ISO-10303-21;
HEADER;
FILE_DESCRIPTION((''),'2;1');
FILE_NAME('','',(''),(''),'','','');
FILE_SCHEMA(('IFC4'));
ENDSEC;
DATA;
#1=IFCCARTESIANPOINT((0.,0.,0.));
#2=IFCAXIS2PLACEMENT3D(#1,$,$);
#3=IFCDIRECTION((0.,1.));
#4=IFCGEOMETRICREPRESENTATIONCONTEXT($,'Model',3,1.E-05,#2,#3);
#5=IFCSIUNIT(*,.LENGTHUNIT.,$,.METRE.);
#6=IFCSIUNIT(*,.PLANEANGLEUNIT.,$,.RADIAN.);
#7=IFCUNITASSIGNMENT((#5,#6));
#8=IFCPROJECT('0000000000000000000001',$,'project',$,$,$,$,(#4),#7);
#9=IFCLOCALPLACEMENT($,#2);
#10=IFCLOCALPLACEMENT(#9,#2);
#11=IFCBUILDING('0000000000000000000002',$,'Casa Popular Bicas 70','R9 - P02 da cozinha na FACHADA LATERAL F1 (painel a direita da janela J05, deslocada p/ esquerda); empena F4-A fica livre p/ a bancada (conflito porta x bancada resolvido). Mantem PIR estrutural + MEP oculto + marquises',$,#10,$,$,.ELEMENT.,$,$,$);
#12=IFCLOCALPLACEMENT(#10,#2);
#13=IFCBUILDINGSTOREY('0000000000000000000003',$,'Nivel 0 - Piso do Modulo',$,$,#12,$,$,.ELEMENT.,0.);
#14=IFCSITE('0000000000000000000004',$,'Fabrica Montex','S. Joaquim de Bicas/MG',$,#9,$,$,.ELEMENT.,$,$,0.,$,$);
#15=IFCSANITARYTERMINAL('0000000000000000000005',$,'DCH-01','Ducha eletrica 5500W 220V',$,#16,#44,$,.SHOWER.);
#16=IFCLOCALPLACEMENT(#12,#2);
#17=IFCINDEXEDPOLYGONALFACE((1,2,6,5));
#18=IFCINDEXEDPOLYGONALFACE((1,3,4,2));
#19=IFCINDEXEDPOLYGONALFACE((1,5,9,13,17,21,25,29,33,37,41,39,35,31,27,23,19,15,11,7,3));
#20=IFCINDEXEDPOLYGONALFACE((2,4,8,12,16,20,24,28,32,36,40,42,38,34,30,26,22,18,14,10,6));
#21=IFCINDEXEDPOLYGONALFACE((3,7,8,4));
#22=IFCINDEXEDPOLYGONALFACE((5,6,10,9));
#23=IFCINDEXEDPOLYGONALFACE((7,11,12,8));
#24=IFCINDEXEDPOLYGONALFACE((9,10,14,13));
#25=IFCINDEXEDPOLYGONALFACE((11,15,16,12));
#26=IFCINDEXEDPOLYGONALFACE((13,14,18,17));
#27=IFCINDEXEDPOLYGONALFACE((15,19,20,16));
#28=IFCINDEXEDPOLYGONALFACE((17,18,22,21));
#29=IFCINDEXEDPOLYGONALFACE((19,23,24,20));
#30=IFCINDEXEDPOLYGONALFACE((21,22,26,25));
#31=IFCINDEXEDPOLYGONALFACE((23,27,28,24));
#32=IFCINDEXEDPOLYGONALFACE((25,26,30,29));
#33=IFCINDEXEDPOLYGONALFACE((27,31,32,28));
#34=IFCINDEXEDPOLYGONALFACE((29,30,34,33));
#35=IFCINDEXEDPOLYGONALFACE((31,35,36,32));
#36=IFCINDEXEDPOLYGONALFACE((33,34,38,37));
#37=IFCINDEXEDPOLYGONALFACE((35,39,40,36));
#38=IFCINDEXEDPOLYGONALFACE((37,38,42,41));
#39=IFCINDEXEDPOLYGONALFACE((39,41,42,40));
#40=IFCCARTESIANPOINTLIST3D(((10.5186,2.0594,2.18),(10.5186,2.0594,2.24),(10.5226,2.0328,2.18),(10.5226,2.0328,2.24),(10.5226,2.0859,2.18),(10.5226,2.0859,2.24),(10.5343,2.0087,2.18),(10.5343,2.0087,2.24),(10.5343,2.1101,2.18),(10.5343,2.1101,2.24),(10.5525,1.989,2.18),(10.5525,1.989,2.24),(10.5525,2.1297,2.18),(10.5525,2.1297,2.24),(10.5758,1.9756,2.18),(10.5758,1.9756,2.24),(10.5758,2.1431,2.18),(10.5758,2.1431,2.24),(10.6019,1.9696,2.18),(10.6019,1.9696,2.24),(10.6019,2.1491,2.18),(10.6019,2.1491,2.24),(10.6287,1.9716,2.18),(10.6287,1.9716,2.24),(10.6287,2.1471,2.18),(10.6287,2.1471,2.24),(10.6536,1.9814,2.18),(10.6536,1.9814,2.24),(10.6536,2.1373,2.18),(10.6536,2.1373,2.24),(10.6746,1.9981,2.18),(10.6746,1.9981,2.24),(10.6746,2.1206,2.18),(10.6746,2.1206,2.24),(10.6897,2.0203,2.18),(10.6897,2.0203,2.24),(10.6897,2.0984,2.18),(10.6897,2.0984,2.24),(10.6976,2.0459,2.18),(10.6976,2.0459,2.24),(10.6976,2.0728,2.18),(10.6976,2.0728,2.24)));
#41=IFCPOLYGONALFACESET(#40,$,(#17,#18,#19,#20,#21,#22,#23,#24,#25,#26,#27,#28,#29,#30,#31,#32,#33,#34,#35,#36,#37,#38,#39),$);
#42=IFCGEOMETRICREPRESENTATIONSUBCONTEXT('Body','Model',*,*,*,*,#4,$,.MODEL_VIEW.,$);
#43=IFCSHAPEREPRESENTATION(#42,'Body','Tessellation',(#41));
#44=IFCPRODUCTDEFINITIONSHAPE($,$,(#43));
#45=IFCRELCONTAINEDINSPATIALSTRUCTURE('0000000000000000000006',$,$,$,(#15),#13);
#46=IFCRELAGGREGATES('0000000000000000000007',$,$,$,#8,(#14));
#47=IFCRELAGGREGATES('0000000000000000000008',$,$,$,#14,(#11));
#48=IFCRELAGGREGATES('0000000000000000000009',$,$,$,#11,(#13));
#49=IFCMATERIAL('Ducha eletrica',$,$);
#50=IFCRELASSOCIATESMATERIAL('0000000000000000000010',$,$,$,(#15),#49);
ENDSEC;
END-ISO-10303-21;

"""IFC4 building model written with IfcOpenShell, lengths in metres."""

from ifc_helpers import new_model, si_unit, direction, frame, origin, origin_2d, place, context, subcontext, project, spatial, circle, extrude, material, element, save


model = new_model("IFC4")

# Units and contexts
model_context = context("Model", 3, precision=1e-05, world=origin(), true_north=direction((0.0, 1.0)))
body_context = subcontext(model_context, "Body", "Model", "MODEL_VIEW")
ifc_project = project(units=[si_unit("LENGTHUNIT", "METRE"), si_unit("PLANEANGLEUNIT", "RADIAN")], contexts=[model_context])

# Site, building, storey
site_placement = place(None, origin())
site = spatial("IfcSite", under=ifc_project, at=site_placement, Name="Fabrica Montex", Description="S. Joaquim de Bicas/MG", CompositionType="ELEMENT", RefElevation=0.0)
building_placement = place(site_placement, origin())
building = spatial("IfcBuilding", under=site, at=building_placement, Name="Casa Popular Bicas 70", Description="R9 - P02 da cozinha na FACHADA LATERAL F1 (painel a direita da janela J05, deslocada p/ esquerda); empena F4-A fica livre p/ a bancada (conflito porta x bancada resolvido). Mantem PIR estrutural + MEP oculto + marquises", CompositionType="ELEMENT")
storey_placement = place(building_placement, origin())
storey = spatial("IfcBuildingStorey", under=building, at=storey_placement, Name="Nivel 0 - Piso do Modulo", CompositionType="ELEMENT", Elevation=0.0)

# Sanitary terminal
ifc_material_1 = material(Name="Ducha eletrica")
sanitary_terminal_1_placement = place(None, frame((10.6086, 2.0594, 2.18), z_axis=(0.0, 0.0, 1.0), x_axis=(-1.0, 0.0, 0.0)))
element("IfcSanitaryTerminal", 1, at=sanitary_terminal_1_placement, inside=storey, material=ifc_material_1, Name="DCH-01", Description="Ducha eletrica 5500W 220V", PredefinedType="SHOWER", context=body_context, shape_type="SweptSolid", body=[
    extrude(circle(Radius=0.09, at=origin_2d()), origin(), (0.0, 0.0, 1.0), 0.06),
])

save(model, "model.ifc")
